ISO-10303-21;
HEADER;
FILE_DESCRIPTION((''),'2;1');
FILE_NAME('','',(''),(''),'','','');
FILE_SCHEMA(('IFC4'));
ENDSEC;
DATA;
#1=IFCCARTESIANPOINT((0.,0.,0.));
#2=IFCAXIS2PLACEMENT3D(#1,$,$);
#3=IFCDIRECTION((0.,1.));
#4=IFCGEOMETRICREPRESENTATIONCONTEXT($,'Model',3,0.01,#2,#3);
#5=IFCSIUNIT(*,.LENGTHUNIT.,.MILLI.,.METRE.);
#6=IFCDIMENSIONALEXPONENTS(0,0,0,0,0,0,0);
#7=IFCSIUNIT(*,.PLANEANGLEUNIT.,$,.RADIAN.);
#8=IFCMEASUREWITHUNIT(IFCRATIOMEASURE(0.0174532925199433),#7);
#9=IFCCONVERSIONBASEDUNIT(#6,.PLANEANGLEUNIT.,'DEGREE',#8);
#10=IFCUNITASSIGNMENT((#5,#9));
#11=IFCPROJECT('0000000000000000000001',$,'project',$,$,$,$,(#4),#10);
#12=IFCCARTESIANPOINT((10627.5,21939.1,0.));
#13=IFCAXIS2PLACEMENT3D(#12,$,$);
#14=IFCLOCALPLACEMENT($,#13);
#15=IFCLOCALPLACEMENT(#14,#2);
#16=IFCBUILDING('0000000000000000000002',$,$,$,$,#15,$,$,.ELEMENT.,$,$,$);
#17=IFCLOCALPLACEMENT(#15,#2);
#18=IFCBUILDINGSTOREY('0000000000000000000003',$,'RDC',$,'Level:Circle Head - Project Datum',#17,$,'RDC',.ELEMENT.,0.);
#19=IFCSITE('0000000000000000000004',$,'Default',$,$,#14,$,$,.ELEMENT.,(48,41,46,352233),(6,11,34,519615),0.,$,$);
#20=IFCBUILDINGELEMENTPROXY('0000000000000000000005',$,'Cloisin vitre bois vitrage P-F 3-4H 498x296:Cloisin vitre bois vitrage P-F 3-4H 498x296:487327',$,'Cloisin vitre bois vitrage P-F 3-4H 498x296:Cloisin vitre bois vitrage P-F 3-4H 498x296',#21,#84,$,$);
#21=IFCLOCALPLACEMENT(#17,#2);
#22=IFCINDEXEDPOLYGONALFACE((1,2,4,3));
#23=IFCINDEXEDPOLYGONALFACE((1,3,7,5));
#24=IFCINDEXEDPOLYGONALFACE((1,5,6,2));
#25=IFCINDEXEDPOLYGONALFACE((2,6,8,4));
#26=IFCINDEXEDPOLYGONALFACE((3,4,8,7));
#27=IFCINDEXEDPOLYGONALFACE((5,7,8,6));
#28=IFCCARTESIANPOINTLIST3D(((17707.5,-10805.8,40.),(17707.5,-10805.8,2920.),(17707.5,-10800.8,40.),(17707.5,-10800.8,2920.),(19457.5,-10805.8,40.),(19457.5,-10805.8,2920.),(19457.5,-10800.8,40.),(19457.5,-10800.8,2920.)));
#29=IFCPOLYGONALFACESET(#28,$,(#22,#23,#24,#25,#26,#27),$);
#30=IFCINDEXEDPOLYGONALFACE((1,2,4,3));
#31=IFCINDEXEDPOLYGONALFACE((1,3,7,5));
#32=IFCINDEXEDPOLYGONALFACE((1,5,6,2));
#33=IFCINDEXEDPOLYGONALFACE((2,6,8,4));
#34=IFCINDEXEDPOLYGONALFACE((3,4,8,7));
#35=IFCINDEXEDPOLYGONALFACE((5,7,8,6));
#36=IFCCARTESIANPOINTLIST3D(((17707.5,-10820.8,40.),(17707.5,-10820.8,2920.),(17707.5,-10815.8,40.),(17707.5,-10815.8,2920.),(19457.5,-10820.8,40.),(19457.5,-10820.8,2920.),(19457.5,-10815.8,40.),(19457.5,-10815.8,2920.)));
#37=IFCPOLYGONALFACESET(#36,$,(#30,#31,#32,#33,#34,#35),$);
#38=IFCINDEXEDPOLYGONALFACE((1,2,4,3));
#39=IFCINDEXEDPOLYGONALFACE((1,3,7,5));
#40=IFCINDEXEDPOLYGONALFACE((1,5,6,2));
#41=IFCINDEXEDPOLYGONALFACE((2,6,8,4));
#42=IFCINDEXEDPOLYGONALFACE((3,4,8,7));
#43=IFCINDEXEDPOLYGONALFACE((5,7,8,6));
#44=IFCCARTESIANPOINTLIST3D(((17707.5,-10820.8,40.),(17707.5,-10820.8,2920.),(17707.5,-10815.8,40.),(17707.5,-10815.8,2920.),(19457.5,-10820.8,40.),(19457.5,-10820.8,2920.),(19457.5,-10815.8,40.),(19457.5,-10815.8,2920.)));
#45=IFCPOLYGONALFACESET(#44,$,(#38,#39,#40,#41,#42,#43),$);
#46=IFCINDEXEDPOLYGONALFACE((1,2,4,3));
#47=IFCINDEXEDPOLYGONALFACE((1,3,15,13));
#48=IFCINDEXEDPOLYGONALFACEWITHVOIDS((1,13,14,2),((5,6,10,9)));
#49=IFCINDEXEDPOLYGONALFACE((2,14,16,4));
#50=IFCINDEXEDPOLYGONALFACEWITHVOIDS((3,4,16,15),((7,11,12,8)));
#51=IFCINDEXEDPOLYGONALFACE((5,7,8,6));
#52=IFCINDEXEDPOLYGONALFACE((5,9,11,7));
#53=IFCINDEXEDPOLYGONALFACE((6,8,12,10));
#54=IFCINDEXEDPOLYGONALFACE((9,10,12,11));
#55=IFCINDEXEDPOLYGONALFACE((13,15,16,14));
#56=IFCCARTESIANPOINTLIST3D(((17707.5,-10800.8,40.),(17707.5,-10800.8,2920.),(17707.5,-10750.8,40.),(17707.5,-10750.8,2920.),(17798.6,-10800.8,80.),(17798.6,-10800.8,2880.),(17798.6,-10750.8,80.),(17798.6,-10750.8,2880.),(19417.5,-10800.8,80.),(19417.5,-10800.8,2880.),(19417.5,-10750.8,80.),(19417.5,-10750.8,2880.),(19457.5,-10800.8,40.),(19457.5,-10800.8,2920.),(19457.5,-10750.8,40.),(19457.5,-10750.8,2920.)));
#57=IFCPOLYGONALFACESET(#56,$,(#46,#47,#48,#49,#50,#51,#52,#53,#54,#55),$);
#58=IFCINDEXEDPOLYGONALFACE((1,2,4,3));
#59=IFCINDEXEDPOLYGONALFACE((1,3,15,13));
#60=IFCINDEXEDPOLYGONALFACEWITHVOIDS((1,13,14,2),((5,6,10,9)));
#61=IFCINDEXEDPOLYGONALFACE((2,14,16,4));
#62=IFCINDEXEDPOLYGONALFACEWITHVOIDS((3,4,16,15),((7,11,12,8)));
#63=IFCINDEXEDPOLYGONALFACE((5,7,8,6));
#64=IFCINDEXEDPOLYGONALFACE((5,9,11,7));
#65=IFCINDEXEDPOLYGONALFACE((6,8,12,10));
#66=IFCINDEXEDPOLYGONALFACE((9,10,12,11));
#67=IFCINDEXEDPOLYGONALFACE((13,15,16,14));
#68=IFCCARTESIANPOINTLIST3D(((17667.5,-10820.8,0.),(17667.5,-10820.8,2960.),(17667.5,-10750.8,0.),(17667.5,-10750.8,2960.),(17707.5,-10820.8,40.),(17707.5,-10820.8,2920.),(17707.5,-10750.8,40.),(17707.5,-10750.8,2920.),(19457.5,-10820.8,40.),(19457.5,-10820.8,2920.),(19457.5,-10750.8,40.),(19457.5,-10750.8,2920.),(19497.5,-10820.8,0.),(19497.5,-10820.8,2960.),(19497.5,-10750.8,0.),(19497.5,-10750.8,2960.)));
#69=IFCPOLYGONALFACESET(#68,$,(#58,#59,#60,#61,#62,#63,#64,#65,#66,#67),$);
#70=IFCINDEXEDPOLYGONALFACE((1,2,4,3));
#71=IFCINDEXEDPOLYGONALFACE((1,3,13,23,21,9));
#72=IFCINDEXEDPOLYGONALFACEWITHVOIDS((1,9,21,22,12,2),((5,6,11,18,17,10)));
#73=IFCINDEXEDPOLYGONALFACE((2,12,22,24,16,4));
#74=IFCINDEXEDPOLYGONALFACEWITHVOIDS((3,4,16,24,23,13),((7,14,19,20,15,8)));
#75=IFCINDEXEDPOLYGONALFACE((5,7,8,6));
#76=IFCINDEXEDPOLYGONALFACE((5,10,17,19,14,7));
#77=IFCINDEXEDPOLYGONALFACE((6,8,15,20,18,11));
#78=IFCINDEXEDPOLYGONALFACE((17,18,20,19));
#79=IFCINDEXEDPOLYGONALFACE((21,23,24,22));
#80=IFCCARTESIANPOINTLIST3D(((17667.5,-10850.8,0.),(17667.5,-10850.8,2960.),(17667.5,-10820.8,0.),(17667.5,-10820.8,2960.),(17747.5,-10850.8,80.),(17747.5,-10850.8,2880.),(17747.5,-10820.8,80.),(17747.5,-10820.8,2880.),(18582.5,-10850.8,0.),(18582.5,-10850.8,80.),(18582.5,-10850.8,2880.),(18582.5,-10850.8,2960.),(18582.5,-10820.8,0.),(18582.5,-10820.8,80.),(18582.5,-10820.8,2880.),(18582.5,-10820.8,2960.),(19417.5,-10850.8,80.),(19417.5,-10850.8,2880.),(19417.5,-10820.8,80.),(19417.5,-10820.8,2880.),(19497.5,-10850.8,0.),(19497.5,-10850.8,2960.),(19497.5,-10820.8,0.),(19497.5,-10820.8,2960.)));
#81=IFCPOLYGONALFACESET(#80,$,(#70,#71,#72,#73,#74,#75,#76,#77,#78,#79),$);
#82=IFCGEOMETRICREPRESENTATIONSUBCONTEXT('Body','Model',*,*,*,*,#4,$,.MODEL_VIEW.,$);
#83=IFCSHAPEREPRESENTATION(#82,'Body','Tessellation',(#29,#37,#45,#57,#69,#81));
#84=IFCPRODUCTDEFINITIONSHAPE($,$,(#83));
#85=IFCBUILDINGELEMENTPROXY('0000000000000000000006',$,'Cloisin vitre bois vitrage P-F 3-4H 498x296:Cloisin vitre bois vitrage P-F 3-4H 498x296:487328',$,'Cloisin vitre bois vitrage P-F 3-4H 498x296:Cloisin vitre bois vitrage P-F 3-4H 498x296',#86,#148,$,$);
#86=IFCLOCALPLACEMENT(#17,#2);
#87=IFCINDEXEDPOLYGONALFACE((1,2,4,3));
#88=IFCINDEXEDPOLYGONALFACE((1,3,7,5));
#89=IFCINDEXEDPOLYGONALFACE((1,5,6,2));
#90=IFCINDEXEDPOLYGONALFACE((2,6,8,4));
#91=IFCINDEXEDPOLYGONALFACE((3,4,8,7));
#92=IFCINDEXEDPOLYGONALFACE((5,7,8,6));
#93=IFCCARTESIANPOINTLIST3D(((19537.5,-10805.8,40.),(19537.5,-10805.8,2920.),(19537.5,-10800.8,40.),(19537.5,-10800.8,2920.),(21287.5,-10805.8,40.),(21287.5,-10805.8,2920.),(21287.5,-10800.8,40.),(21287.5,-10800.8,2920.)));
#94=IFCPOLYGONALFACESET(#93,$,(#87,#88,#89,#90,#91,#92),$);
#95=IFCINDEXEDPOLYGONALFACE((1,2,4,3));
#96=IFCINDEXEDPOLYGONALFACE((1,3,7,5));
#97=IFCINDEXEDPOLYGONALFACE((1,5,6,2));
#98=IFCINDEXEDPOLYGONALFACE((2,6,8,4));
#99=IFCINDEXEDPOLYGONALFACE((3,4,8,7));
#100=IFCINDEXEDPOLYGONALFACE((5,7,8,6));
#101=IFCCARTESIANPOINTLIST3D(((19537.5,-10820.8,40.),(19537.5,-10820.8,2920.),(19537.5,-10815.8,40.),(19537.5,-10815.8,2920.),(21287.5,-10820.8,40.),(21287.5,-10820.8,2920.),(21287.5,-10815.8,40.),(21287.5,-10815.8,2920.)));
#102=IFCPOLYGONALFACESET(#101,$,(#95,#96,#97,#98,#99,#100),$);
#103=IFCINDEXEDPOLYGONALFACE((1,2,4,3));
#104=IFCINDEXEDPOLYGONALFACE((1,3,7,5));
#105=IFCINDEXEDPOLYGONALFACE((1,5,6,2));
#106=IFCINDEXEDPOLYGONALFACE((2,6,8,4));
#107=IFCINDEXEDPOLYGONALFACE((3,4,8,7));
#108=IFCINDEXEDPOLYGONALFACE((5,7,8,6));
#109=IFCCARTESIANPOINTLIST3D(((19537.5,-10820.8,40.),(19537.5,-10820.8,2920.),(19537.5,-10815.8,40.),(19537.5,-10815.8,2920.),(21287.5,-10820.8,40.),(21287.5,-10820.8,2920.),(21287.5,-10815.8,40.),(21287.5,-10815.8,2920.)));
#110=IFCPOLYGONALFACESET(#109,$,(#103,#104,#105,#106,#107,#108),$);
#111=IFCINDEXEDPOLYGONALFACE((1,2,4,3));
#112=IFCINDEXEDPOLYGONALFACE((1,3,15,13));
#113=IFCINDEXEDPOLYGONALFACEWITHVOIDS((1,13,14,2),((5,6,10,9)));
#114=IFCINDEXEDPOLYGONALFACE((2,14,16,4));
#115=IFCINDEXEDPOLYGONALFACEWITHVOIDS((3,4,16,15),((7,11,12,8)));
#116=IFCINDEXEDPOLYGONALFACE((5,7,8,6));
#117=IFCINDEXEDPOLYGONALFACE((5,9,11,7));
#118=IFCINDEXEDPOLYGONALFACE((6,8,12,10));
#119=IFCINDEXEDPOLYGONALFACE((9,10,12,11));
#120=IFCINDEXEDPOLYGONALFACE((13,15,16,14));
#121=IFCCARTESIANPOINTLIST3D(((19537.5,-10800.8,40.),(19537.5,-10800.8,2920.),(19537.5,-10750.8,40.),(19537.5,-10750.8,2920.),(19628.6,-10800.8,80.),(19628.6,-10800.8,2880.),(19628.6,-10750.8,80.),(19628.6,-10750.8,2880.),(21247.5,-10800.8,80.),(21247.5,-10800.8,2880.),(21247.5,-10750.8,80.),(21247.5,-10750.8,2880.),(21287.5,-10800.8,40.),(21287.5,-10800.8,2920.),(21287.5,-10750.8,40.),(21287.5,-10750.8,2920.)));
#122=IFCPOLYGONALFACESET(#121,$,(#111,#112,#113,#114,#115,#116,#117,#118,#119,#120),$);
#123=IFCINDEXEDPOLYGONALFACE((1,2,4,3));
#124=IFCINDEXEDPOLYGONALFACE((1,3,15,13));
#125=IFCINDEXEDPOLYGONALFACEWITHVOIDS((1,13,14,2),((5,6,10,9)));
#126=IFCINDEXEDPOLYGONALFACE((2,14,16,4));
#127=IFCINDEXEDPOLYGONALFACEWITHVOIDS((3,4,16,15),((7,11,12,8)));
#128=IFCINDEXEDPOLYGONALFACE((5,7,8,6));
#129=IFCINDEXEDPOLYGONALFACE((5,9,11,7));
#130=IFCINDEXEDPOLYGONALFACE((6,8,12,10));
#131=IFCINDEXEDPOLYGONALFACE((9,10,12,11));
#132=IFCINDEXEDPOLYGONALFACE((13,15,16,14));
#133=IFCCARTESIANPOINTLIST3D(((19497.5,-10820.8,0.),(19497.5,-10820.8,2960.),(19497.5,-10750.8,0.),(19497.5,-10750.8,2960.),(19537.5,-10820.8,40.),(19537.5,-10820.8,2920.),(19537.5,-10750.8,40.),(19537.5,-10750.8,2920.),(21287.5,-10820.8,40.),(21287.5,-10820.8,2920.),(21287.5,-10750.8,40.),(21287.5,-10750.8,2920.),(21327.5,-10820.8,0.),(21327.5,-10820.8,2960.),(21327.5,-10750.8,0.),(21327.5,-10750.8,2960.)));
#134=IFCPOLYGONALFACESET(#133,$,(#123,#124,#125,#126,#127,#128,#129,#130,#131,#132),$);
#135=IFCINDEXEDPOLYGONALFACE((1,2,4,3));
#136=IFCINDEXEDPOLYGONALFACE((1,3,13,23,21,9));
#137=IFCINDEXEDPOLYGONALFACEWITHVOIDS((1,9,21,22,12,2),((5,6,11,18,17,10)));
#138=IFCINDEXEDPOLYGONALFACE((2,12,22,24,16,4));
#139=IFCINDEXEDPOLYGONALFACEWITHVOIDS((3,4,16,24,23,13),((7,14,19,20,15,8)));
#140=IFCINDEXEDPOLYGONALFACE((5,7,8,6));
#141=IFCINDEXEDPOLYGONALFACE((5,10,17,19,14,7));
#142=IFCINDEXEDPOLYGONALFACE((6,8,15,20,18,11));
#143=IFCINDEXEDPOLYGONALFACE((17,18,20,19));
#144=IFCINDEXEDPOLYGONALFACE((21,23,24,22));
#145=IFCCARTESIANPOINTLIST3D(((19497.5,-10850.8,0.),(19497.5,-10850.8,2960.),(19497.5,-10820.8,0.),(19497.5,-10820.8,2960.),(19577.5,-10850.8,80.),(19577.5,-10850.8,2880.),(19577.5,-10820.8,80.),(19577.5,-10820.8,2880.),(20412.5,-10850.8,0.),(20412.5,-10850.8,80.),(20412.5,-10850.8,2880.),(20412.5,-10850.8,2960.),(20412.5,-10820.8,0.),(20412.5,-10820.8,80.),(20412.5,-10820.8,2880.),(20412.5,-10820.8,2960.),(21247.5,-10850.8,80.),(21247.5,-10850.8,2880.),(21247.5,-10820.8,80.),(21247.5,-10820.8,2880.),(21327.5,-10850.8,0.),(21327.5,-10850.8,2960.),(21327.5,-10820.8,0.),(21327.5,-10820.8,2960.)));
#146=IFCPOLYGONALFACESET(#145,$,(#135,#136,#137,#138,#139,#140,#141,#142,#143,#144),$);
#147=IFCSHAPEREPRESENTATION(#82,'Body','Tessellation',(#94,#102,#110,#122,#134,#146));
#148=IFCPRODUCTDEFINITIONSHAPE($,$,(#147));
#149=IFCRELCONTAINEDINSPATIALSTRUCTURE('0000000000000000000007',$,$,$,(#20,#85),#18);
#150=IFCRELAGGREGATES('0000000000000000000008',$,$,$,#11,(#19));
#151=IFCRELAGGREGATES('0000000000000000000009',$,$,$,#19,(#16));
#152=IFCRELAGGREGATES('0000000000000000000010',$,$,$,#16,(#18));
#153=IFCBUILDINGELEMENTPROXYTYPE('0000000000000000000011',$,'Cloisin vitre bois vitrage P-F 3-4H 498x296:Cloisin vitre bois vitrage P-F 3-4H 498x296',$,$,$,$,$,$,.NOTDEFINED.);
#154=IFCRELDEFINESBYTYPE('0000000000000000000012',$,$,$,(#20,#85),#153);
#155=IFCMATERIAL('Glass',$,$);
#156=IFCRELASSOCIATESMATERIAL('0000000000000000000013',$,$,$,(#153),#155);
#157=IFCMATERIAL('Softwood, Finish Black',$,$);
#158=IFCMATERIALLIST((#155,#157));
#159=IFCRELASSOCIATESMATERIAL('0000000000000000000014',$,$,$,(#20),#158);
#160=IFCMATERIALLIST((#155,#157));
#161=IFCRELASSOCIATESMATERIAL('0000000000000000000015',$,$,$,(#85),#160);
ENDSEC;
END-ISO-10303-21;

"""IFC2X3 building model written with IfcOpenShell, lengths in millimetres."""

from ifc_helpers import new_model, entity, si_unit, converted_unit, direction, frame, frame_2d, origin, place, context, subcontext, project, spatial, polyline, rectangle, outline, extrude, source, transform, mapped, material, material_list, type_object, type_shapes, element, save


model = new_model("IFC2X3")

# Units and contexts
model_context = context("Model", 3, precision=0.01, world=origin(), true_north=direction((0.0, 1.0)))
body_context = subcontext(model_context, "Body", "Model", "MODEL_VIEW")
ifc_project = project(units=[si_unit("LENGTHUNIT", "METRE", prefix="MILLI"), converted_unit("PLANEANGLEUNIT", "DEGREE", entity("IfcRatioMeasure", 0.0174532925199433), si_unit("PLANEANGLEUNIT", "RADIAN"), dimensions=[0, 0, 0, 0, 0, 0, 0])], contexts=[model_context])

# Site, building, storey
site_placement = place(None, frame((10627.5, 21939.1, 0.0)))
site = spatial("IfcSite", under=ifc_project, at=site_placement, Name="Default", CompositionType="ELEMENT", RefLatitude=(48, 41, 46, 352233), RefLongitude=(6, 11, 34, 519615), RefElevation=0.0)
building_placement = place(site_placement, origin())
building = spatial("IfcBuilding", under=site, at=building_placement, CompositionType="ELEMENT")
storey_placement = place(building_placement, origin())
storey = spatial("IfcBuildingStorey", under=building, at=storey_placement, Name="RDC", ObjectType="Level:Circle Head - Project Datum", LongName="RDC", CompositionType="ELEMENT", Elevation=0.0)

# Building element proxies
ifc_material_1 = material(Name="Glass")
ifc_material_2 = material(Name="Softwood, Finish Black")
building_element_proxy_type_1 = type_object("IfcBuildingElementProxyType", Name="Cloisin vitre bois vitrage P-F 3-4H 498x296:Cloisin vitre bois vitrage P-F 3-4H 498x296", PredefinedType="NOTDEFINED", material=ifc_material_1)
shared_shape_1 = source(origin(), body_context, "Body", "SweptSolid", [
    extrude(rectangle(XDim=5.0, YDim=1750.0, at=frame_2d((0.0, 0.0), x_axis=(1.0, 0.0))), frame((0.0, -47.5, 40.0), z_axis=(0.0, 0.0, 1.0), x_axis=(0.0, 1.0, 0.0)), (0.0, 0.0, 1.0), 2880.0),
    extrude(rectangle(XDim=5.0, YDim=1750.0, at=frame_2d((0.0, 0.0), x_axis=(1.0, 0.0))), frame((0.0, -32.5, 40.0), z_axis=(0.0, 0.0, 1.0), x_axis=(0.0, 1.0, 0.0)), (0.0, 0.0, 1.0), 2880.0),
    extrude(rectangle(XDim=5.0, YDim=1750.0, at=frame_2d((0.0, 0.0), x_axis=(1.0, 0.0))), frame((0.0, -32.5, 40.0), z_axis=(0.0, 0.0, 1.0), x_axis=(0.0, 1.0, 0.0)), (0.0, 0.0, 1.0), 2880.0),
    extrude(outline(polyline([(-1440.0, -875.0), (1440.0, -875.0), (1440.0, 875.0), (-1440.0, 875.0), (-1440.0, -875.0)]), holes=[polyline([(1400.0, 835.0), (1400.0, -783.9), (-1400.0, -783.9), (-1400.0, 835.0), (1400.0, 835.0)])]), frame((0.0, -100.0, 1480.0), z_axis=(0.0, 1.0, 0.0), x_axis=(0.0, 0.0, -1.0)), (0.0, 0.0, 1.0), 50.0),
    extrude(outline(polyline([(-1480.0, -915.0), (1480.0, -915.0), (1480.0, 915.0), (-1480.0, 915.0), (-1480.0, -915.0)]), holes=[polyline([(-1440.0, -875.0), (-1440.0, 875.0), (1440.0, 875.0), (1440.0, -875.0), (-1440.0, -875.0)])]), frame((0.0, -100.0, 1480.0), z_axis=(0.0, 1.0, 0.0), x_axis=(0.0, 0.0, -1.0)), (0.0, 0.0, 1.0), 70.0),
    extrude(outline(polyline([(-1480.0, -915.0), (1480.0, -915.0), (1480.0, 0.0), (1480.0, 915.0), (-1480.0, 915.0), (-1480.0, 0.0), (-1480.0, -915.0)]), holes=[polyline([(1400.0, 0.0), (1400.0, -835.0), (-1400.0, -835.0), (-1400.0, 0.0), (-1400.0, 835.0), (1400.0, 835.0), (1400.0, 0.0)])]), frame((0.0, -30.0, 1480.0), z_axis=(0.0, 1.0, 0.0), x_axis=(0.0, 0.0, 1.0)), (0.0, 0.0, 1.0), 30.0),
])
type_shapes(building_element_proxy_type_1, [shared_shape_1])
ifc_material_list_1 = material_list([ifc_material_1, ifc_material_2])
proxy_1_placement = place(storey_placement, frame((18582.5, -10850.8, 0.0), z_axis=(0.0, 0.0, 1.0), x_axis=(-1.0, 0.0, 0.0)))
element("IfcBuildingElementProxy", 1, at=proxy_1_placement, inside=storey, type_object=building_element_proxy_type_1, material=ifc_material_list_1, Name="Cloisin vitre bois vitrage P-F 3-4H 498x296:Cloisin vitre bois vitrage P-F 3-4H 498x296:487327", ObjectType="Cloisin vitre bois vitrage P-F 3-4H 498x296:Cloisin vitre bois vitrage P-F 3-4H 498x296", context=body_context, shape_type="MappedRepresentation", body=[
    mapped(shared_shape_1, transform((0.0, 0.0, 0.0), scale=1.0)),
])
ifc_material_list_2 = material_list([ifc_material_1, ifc_material_2])
proxy_2_placement = place(storey_placement, frame((20412.5, -10850.8, 0.0), z_axis=(0.0, 0.0, 1.0), x_axis=(-1.0, 0.0, 0.0)))
element("IfcBuildingElementProxy", 2, at=proxy_2_placement, inside=storey, type_object=building_element_proxy_type_1, material=ifc_material_list_2, Name="Cloisin vitre bois vitrage P-F 3-4H 498x296:Cloisin vitre bois vitrage P-F 3-4H 498x296:487328", ObjectType="Cloisin vitre bois vitrage P-F 3-4H 498x296:Cloisin vitre bois vitrage P-F 3-4H 498x296", context=body_context, shape_type="MappedRepresentation", body=[
    mapped(shared_shape_1, transform((0.0, 0.0, 0.0), scale=1.0)),
])

save(model, "model.ifc")
